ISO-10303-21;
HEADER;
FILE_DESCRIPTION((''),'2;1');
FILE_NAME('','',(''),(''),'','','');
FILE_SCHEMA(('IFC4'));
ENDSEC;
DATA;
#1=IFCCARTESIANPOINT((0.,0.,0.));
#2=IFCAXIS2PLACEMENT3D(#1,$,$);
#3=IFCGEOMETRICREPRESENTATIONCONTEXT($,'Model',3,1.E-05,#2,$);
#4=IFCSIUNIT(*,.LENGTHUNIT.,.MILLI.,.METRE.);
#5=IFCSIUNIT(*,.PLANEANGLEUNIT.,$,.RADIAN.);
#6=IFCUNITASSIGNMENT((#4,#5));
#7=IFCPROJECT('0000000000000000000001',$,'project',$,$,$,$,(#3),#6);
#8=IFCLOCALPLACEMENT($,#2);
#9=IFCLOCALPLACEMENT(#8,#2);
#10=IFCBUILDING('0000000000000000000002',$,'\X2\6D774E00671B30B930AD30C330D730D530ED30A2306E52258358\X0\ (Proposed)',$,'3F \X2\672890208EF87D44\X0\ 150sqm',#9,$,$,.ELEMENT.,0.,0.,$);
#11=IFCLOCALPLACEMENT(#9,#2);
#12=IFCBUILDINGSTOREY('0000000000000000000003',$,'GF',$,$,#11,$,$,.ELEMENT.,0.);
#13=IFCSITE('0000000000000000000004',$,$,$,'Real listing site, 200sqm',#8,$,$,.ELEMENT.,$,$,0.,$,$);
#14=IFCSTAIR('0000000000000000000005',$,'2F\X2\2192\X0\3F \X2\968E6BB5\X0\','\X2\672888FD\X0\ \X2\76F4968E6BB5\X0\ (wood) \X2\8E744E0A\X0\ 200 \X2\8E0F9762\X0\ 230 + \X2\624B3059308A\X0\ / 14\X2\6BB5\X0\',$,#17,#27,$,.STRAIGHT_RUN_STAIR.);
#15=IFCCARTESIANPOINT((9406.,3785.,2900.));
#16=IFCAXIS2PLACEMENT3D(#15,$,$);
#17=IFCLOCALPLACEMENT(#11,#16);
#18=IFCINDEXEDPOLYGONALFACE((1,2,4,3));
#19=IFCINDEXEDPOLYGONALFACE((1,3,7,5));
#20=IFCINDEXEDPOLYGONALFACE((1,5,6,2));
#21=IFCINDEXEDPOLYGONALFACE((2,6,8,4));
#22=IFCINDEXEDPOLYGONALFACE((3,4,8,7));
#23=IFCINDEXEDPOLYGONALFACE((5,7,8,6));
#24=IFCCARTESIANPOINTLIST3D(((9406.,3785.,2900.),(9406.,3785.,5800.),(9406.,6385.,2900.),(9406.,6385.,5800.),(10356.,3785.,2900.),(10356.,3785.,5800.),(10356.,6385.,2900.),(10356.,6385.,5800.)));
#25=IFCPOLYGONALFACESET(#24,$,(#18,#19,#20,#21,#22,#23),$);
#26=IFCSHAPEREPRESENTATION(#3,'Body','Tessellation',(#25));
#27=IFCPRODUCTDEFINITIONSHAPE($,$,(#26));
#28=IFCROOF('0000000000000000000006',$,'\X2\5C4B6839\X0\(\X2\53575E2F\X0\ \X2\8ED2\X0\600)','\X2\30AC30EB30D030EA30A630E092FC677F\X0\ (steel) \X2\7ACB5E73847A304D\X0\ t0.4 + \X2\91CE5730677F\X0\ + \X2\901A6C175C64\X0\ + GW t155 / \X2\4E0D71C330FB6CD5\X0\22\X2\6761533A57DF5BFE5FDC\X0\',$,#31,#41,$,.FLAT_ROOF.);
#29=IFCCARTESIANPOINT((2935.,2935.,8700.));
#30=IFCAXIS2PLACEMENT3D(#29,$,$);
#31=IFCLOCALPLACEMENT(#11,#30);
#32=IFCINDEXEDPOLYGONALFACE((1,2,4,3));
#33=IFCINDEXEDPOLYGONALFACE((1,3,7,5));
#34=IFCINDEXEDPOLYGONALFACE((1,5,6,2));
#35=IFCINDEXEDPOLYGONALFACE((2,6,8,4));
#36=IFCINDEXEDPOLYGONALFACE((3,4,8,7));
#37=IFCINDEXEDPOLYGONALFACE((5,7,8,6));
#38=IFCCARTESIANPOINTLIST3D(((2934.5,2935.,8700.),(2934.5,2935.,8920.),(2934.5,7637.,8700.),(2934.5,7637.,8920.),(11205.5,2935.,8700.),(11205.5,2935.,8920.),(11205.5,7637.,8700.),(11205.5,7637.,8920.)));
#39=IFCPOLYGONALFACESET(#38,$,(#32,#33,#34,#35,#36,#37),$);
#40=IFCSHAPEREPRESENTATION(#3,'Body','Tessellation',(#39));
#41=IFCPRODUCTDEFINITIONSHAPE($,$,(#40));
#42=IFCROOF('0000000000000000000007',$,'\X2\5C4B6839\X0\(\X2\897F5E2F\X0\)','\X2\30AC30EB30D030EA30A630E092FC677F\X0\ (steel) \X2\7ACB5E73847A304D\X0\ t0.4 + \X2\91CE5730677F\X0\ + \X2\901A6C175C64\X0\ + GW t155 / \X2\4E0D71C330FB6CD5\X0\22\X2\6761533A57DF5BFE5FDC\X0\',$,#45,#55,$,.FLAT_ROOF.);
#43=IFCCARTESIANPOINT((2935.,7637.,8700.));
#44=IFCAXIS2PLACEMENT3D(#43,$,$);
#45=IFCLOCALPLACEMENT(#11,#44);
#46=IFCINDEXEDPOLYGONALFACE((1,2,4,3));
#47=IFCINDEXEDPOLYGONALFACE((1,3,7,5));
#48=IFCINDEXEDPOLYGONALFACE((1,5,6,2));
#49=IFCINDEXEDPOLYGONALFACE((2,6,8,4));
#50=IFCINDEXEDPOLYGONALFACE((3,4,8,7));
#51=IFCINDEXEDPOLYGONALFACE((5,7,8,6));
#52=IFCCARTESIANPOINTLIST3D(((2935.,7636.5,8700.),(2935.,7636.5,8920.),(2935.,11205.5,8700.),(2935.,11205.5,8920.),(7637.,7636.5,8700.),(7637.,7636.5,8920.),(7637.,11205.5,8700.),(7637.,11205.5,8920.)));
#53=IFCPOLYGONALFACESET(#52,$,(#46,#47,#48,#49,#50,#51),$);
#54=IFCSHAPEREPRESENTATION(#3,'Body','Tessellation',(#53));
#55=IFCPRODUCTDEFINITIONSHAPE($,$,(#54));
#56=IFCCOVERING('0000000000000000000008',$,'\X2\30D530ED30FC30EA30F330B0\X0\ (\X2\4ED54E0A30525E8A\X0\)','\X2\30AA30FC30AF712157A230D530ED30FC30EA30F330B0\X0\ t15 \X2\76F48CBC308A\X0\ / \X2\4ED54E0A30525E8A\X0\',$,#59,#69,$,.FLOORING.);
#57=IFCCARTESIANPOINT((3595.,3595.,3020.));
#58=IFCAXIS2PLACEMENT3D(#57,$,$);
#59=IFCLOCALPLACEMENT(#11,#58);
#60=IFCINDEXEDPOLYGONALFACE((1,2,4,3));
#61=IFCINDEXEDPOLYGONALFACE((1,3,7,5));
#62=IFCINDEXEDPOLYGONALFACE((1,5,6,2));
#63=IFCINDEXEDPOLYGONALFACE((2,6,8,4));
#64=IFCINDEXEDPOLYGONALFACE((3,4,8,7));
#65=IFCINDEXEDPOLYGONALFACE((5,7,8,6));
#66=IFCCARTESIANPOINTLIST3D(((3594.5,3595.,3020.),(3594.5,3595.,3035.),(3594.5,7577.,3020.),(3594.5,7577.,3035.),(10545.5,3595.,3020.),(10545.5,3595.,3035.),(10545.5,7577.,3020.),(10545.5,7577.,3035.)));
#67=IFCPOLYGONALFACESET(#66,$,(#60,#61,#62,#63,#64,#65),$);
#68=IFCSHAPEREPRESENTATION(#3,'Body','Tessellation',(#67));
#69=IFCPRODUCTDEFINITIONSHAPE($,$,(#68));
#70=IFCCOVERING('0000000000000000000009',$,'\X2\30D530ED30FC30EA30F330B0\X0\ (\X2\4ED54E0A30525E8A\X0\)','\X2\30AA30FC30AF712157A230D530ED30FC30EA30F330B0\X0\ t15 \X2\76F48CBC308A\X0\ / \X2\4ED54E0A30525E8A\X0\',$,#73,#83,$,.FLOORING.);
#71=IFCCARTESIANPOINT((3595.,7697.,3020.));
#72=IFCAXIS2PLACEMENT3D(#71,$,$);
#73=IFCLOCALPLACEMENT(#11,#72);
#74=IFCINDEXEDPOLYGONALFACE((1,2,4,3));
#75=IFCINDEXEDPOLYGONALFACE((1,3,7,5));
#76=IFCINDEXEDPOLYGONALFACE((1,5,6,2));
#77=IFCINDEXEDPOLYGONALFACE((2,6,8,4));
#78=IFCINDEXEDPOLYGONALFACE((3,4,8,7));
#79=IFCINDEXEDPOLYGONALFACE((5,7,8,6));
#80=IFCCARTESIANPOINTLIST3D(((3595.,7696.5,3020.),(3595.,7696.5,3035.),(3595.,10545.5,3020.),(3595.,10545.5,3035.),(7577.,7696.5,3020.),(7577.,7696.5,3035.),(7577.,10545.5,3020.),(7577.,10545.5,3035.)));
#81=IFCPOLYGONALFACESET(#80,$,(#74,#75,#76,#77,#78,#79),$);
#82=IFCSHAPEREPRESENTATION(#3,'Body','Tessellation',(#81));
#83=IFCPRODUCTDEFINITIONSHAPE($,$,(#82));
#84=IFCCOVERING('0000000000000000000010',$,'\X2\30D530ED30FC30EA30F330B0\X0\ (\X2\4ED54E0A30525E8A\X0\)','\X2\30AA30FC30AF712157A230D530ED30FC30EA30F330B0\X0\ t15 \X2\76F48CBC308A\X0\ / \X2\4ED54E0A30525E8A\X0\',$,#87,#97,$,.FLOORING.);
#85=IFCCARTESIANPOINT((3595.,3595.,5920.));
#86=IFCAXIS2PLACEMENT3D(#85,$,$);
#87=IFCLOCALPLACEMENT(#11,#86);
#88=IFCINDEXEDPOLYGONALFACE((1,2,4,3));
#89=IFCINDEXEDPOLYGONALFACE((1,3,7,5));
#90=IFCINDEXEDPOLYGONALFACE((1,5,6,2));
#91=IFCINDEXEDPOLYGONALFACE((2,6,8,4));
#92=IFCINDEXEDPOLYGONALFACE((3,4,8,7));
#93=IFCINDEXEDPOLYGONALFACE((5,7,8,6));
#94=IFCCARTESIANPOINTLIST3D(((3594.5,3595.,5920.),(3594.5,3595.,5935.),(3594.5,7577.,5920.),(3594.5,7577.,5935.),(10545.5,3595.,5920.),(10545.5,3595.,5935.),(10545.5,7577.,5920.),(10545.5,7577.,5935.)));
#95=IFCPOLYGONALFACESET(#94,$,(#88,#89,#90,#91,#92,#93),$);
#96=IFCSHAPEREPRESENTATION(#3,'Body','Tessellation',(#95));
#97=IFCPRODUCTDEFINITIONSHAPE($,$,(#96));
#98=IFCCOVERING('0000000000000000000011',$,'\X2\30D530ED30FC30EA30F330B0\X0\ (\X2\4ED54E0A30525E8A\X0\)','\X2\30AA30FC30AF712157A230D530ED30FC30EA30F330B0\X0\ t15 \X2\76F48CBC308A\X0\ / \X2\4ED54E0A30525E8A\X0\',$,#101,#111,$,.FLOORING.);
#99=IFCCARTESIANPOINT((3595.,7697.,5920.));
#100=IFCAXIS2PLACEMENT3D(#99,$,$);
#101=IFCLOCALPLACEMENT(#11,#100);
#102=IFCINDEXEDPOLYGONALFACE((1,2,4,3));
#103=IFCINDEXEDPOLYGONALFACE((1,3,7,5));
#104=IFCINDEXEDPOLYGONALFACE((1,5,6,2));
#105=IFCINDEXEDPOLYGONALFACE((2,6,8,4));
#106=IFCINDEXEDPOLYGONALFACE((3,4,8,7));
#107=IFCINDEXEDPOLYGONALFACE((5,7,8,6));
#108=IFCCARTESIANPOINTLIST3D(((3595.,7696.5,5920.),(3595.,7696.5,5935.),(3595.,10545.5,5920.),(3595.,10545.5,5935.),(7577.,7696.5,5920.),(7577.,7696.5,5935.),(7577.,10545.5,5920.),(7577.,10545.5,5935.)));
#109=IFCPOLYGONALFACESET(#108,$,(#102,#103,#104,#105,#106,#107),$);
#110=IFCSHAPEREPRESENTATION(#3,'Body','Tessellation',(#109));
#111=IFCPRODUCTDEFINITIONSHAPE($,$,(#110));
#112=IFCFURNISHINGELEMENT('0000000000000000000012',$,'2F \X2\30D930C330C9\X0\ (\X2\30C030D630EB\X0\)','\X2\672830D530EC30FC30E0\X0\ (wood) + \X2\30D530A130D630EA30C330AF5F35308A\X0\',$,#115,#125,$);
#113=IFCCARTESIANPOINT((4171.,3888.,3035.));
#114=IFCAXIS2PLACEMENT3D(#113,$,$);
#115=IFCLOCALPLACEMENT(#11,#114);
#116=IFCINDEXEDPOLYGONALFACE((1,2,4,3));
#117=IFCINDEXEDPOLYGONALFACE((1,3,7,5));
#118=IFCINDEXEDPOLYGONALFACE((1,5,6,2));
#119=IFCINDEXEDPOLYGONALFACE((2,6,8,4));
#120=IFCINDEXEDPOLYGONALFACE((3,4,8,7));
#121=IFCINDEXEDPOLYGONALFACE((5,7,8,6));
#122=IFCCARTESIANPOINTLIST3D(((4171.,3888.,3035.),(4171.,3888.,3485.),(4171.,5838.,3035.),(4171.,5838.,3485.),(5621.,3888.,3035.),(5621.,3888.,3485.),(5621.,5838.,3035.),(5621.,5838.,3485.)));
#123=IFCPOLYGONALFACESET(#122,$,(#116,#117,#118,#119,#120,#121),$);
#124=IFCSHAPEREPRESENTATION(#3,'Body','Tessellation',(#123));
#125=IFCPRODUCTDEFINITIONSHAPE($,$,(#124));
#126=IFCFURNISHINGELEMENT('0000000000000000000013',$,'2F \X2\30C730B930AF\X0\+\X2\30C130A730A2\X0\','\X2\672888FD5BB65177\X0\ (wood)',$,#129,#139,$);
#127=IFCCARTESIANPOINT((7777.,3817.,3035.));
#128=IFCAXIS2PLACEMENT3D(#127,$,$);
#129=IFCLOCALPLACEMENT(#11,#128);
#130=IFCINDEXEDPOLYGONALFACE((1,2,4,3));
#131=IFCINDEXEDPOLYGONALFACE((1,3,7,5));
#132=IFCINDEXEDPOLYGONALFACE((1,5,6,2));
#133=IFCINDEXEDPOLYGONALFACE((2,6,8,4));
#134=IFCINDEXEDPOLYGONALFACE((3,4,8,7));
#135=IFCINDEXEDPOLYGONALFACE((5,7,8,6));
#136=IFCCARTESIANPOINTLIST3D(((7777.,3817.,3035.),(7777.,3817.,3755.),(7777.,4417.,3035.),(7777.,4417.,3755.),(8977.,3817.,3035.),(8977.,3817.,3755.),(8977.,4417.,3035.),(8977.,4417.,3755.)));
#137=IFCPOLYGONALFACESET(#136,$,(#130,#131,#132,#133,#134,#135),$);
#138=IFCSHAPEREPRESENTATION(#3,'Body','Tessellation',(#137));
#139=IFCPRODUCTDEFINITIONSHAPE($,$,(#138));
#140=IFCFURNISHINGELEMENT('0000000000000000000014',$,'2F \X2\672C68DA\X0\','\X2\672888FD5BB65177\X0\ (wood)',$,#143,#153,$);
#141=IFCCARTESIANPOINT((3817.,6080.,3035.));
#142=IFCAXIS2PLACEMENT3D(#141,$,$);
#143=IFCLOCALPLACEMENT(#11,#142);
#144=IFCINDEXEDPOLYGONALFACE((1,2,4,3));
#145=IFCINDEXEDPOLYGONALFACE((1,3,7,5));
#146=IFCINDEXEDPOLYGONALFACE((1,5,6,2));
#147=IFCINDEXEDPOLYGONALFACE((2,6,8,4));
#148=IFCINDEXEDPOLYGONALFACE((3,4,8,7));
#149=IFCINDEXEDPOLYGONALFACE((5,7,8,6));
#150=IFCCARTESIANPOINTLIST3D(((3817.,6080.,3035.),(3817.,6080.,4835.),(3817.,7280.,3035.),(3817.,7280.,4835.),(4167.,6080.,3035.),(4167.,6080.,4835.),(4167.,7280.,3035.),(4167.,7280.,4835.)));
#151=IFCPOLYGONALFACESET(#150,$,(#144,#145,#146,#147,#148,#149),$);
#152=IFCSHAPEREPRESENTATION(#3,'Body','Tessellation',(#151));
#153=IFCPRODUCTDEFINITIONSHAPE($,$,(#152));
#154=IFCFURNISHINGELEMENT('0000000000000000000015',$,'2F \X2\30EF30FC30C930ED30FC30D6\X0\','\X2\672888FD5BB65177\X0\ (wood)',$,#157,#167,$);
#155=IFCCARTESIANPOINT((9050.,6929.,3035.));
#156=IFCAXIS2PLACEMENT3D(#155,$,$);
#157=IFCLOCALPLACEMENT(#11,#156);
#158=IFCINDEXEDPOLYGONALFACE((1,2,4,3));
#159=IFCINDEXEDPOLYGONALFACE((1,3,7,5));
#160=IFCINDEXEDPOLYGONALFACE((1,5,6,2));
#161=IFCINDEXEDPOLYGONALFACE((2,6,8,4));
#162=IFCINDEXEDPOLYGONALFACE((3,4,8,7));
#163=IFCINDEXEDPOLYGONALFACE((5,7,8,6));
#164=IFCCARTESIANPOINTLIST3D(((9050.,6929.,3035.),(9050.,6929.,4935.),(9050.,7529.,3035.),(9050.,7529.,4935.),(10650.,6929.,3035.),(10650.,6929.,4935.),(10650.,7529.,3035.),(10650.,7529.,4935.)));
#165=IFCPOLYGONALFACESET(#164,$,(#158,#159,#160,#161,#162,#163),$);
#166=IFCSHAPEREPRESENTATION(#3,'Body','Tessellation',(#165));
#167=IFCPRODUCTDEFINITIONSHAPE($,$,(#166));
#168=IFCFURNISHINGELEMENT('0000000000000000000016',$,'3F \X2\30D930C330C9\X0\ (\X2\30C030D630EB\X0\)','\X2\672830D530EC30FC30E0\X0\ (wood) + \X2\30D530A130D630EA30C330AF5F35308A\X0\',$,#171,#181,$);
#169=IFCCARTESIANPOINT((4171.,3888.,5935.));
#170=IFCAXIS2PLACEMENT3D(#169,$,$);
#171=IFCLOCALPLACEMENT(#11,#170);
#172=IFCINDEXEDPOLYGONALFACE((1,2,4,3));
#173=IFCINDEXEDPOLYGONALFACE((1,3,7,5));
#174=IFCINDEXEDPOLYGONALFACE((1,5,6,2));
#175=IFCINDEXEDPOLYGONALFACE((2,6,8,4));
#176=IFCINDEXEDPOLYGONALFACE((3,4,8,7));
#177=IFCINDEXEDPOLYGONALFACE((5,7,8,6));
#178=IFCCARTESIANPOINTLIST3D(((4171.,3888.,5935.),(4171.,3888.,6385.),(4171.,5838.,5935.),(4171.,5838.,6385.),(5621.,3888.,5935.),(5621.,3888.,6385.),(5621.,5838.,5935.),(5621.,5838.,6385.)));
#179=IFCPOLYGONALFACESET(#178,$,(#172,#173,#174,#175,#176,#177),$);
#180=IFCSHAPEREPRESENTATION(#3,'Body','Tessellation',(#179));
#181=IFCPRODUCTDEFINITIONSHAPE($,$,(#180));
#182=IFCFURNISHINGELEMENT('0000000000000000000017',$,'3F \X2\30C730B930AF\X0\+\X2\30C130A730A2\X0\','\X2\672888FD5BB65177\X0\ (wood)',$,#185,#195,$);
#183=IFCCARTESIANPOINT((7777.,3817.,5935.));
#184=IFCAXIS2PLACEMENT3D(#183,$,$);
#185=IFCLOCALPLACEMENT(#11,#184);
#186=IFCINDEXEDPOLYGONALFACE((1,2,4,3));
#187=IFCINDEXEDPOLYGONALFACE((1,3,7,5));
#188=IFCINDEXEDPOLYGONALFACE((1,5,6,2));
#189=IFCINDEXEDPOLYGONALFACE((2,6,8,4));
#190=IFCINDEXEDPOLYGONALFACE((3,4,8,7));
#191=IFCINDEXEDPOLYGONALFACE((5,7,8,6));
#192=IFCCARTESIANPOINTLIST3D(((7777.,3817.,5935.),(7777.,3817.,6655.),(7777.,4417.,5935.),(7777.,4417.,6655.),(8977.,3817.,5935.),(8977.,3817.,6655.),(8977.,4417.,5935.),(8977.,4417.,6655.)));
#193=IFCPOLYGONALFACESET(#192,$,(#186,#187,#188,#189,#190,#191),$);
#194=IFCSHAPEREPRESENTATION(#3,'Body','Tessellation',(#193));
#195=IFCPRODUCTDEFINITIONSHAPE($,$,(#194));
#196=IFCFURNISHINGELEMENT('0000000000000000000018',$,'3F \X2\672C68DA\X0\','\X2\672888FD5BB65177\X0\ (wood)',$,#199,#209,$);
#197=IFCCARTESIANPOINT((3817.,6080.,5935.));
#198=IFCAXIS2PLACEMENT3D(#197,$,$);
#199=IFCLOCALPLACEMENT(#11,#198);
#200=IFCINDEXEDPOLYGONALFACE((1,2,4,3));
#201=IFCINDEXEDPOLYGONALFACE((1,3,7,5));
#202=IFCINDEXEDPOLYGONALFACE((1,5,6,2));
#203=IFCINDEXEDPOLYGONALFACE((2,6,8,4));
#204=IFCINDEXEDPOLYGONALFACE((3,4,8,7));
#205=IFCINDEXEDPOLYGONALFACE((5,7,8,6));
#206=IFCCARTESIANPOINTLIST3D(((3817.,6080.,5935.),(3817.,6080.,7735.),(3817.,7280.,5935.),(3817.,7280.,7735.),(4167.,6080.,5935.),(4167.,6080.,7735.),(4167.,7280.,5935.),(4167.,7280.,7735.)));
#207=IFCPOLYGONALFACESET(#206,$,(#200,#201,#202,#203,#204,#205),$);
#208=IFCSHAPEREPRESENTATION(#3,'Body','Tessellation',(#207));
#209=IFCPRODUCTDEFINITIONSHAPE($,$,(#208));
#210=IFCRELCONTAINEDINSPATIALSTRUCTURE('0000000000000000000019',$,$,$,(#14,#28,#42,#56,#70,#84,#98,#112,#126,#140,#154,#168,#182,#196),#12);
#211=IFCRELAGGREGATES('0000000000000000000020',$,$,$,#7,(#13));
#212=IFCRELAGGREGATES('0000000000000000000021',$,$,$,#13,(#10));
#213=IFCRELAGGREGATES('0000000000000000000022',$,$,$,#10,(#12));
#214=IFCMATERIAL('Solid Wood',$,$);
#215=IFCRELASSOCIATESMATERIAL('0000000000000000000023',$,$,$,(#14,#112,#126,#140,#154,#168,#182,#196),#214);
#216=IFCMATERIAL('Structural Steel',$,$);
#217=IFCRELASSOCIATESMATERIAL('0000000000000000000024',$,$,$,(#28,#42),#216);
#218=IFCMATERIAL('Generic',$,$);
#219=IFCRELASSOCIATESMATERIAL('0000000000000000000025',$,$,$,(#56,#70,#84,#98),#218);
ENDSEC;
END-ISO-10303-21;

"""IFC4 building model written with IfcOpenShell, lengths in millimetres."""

from ifc_helpers import new_model, si_unit, frame, frame_2d, origin, place, context, project, spatial, rectangle, extrude, material, element, save


model = new_model("IFC4")

# Units and contexts
model_context = context("Model", 3, precision=1e-05, world=origin())
ifc_project = project(units=[si_unit("LENGTHUNIT", "METRE", prefix="MILLI"), si_unit("PLANEANGLEUNIT", "RADIAN")], contexts=[model_context])

# Site, building, storey
site_placement = place(None, origin())
site = spatial("IfcSite", under=ifc_project, at=site_placement, ObjectType="Real listing site, 200sqm", CompositionType="ELEMENT", RefElevation=0.0)
building_placement = place(site_placement, origin())
building = spatial("IfcBuilding", under=site, at=building_placement, Name="海一望スキップフロアの別荘 (Proposed)", ObjectType="3F 木造軸組 150sqm", CompositionType="ELEMENT", ElevationOfRefHeight=0.0, ElevationOfTerrain=0.0)
storey_placement = place(building_placement, origin())
storey = spatial("IfcBuildingStorey", under=building, at=storey_placement, Name="GF", CompositionType="ELEMENT", Elevation=0.0)

# Shared definitions
ifc_material_1 = material(Name="Solid Wood")

# Stair
stair_placement = place(storey_placement, frame((9406.0, 3785.0, 2900.0)))
element("IfcStair", 1, at=stair_placement, inside=storey, material=ifc_material_1, Name="2F→3F 階段", Description="木製 直階段 (wood) 蹴上 200 踏面 230 + 手すり / 14段", PredefinedType="STRAIGHT_RUN_STAIR", context=model_context, shape_type="SweptSolid", body=[
    extrude(rectangle(XDim=950.0, YDim=2600.0, at=frame_2d((475.0, 1300.0))), frame((9406.0, 3785.0, 2900.0)), (0.0, 0.0, 1.0), 2900.0),
])

# Roofs
ifc_material_2 = material(Name="Structural Steel")
roof_1_placement = place(storey_placement, frame((2935.0, 2935.0, 8700.0)))
element("IfcRoof", 2, at=roof_1_placement, inside=storey, material=ifc_material_2, Name="屋根(南帯 軒600)", Description="ガルバリウム鋼板 (steel) 立平葺き t0.4 + 野地板 + 通気層 + GW t155 / 不燃・法22条区域対応", PredefinedType="FLAT_ROOF", context=model_context, shape_type="SweptSolid", body=[
    extrude(rectangle(XDim=8271.0, YDim=4702.0, at=frame_2d((4135.0, 2351.0))), frame((2935.0, 2935.0, 8700.0)), (0.0, 0.0, 1.0), 220.0),
])
roof_2_placement = place(storey_placement, frame((2935.0, 7637.0, 8700.0)))
element("IfcRoof", 3, at=roof_2_placement, inside=storey, material=ifc_material_2, Name="屋根(西帯)", Description="ガルバリウム鋼板 (steel) 立平葺き t0.4 + 野地板 + 通気層 + GW t155 / 不燃・法22条区域対応", PredefinedType="FLAT_ROOF", context=model_context, shape_type="SweptSolid", body=[
    extrude(rectangle(XDim=4702.0, YDim=3569.0, at=frame_2d((2351.0, 1784.0))), frame((2935.0, 7637.0, 8700.0)), (0.0, 0.0, 1.0), 220.0),
])

# Coverings
ifc_material_3 = material(Name="Generic")
covering_1_placement = place(storey_placement, frame((3595.0, 3595.0, 3020.0)))
element("IfcCovering", 4, at=covering_1_placement, inside=storey, material=ifc_material_3, Name="フローリング (仕上げ床)", Description="オーク無垢フローリング t15 直貼り / 仕上げ床", PredefinedType="FLOORING", context=model_context, shape_type="SweptSolid", body=[
    extrude(rectangle(XDim=6951.0, YDim=3982.0, at=frame_2d((3475.0, 1991.0))), frame((3595.0, 3595.0, 3020.0)), (0.0, 0.0, 1.0), 15.0),
])
covering_2_placement = place(storey_placement, frame((3595.0, 7697.0, 3020.0)))
element("IfcCovering", 5, at=covering_2_placement, inside=storey, material=ifc_material_3, Name="フローリング (仕上げ床)", Description="オーク無垢フローリング t15 直貼り / 仕上げ床", PredefinedType="FLOORING", context=model_context, shape_type="SweptSolid", body=[
    extrude(rectangle(XDim=3982.0, YDim=2849.0, at=frame_2d((1991.0, 1424.0))), frame((3595.0, 7697.0, 3020.0)), (0.0, 0.0, 1.0), 15.0),
])
covering_3_placement = place(storey_placement, frame((3595.0, 3595.0, 5920.0)))
element("IfcCovering", 6, at=covering_3_placement, inside=storey, material=ifc_material_3, Name="フローリング (仕上げ床)", Description="オーク無垢フローリング t15 直貼り / 仕上げ床", PredefinedType="FLOORING", context=model_context, shape_type="SweptSolid", body=[
    extrude(rectangle(XDim=6951.0, YDim=3982.0, at=frame_2d((3475.0, 1991.0))), frame((3595.0, 3595.0, 5920.0)), (0.0, 0.0, 1.0), 15.0),
])
covering_4_placement = place(storey_placement, frame((3595.0, 7697.0, 5920.0)))
element("IfcCovering", 7, at=covering_4_placement, inside=storey, material=ifc_material_3, Name="フローリング (仕上げ床)", Description="オーク無垢フローリング t15 直貼り / 仕上げ床", PredefinedType="FLOORING", context=model_context, shape_type="SweptSolid", body=[
    extrude(rectangle(XDim=3982.0, YDim=2849.0, at=frame_2d((1991.0, 1424.0))), frame((3595.0, 7697.0, 5920.0)), (0.0, 0.0, 1.0), 15.0),
])

# Furnishing elements
furnishing_1_placement = place(storey_placement, frame((4171.0, 3888.0, 3035.0)))
element("IfcFurnishingElement", 8, at=furnishing_1_placement, inside=storey, material=ifc_material_1, Name="2F ベッド (ダブル)", Description="木フレーム (wood) + ファブリック張り", context=model_context, shape_type="SweptSolid", body=[
    extrude(rectangle(XDim=1450.0, YDim=1950.0, at=frame_2d((725.0, 975.0))), frame((4171.0, 3888.0, 3035.0)), (0.0, 0.0, 1.0), 450.0),
])
furnishing_2_placement = place(storey_placement, frame((7777.0, 3817.0, 3035.0)))
element("IfcFurnishingElement", 9, at=furnishing_2_placement, inside=storey, material=ifc_material_1, Name="2F デスク+チェア", Description="木製家具 (wood)", context=model_context, shape_type="SweptSolid", body=[
    extrude(rectangle(XDim=1200.0, YDim=600.0, at=frame_2d((600.0, 300.0))), frame((7777.0, 3817.0, 3035.0)), (0.0, 0.0, 1.0), 720.0),
])
furnishing_3_placement = place(storey_placement, frame((3817.0, 6080.0, 3035.0)))
element("IfcFurnishingElement", 10, at=furnishing_3_placement, inside=storey, material=ifc_material_1, Name="2F 本棚", Description="木製家具 (wood)", context=model_context, shape_type="SweptSolid", body=[
    extrude(rectangle(XDim=350.0, YDim=1200.0, at=frame_2d((175.0, 600.0))), frame((3817.0, 6080.0, 3035.0)), (0.0, 0.0, 1.0), 1800.0),
])
furnishing_4_placement = place(storey_placement, frame((9050.0, 6929.0, 3035.0)))
element("IfcFurnishingElement", 11, at=furnishing_4_placement, inside=storey, material=ifc_material_1, Name="2F ワードローブ", Description="木製家具 (wood)", context=model_context, shape_type="SweptSolid", body=[
    extrude(rectangle(XDim=1600.0, YDim=600.0, at=frame_2d((800.0, 300.0))), frame((9050.0, 6929.0, 3035.0)), (0.0, 0.0, 1.0), 1900.0),
])
furnishing_5_placement = place(storey_placement, frame((4171.0, 3888.0, 5935.0)))
element("IfcFurnishingElement", 12, at=furnishing_5_placement, inside=storey, material=ifc_material_1, Name="3F ベッド (ダブル)", Description="木フレーム (wood) + ファブリック張り", context=model_context, shape_type="SweptSolid", body=[
    extrude(rectangle(XDim=1450.0, YDim=1950.0, at=frame_2d((725.0, 975.0))), frame((4171.0, 3888.0, 5935.0)), (0.0, 0.0, 1.0), 450.0),
])
furnishing_6_placement = place(storey_placement, frame((7777.0, 3817.0, 5935.0)))
element("IfcFurnishingElement", 13, at=furnishing_6_placement, inside=storey, material=ifc_material_1, Name="3F デスク+チェア", Description="木製家具 (wood)", context=model_context, shape_type="SweptSolid", body=[
    extrude(rectangle(XDim=1200.0, YDim=600.0, at=frame_2d((600.0, 300.0))), frame((7777.0, 3817.0, 5935.0)), (0.0, 0.0, 1.0), 720.0),
])
furnishing_7_placement = place(storey_placement, frame((3817.0, 6080.0, 5935.0)))
element("IfcFurnishingElement", 14, at=furnishing_7_placement, inside=storey, material=ifc_material_1, Name="3F 本棚", Description="木製家具 (wood)", context=model_context, shape_type="SweptSolid", body=[
    extrude(rectangle(XDim=350.0, YDim=1200.0, at=frame_2d((175.0, 600.0))), frame((3817.0, 6080.0, 5935.0)), (0.0, 0.0, 1.0), 1800.0),
])

save(model, "model.ifc")
